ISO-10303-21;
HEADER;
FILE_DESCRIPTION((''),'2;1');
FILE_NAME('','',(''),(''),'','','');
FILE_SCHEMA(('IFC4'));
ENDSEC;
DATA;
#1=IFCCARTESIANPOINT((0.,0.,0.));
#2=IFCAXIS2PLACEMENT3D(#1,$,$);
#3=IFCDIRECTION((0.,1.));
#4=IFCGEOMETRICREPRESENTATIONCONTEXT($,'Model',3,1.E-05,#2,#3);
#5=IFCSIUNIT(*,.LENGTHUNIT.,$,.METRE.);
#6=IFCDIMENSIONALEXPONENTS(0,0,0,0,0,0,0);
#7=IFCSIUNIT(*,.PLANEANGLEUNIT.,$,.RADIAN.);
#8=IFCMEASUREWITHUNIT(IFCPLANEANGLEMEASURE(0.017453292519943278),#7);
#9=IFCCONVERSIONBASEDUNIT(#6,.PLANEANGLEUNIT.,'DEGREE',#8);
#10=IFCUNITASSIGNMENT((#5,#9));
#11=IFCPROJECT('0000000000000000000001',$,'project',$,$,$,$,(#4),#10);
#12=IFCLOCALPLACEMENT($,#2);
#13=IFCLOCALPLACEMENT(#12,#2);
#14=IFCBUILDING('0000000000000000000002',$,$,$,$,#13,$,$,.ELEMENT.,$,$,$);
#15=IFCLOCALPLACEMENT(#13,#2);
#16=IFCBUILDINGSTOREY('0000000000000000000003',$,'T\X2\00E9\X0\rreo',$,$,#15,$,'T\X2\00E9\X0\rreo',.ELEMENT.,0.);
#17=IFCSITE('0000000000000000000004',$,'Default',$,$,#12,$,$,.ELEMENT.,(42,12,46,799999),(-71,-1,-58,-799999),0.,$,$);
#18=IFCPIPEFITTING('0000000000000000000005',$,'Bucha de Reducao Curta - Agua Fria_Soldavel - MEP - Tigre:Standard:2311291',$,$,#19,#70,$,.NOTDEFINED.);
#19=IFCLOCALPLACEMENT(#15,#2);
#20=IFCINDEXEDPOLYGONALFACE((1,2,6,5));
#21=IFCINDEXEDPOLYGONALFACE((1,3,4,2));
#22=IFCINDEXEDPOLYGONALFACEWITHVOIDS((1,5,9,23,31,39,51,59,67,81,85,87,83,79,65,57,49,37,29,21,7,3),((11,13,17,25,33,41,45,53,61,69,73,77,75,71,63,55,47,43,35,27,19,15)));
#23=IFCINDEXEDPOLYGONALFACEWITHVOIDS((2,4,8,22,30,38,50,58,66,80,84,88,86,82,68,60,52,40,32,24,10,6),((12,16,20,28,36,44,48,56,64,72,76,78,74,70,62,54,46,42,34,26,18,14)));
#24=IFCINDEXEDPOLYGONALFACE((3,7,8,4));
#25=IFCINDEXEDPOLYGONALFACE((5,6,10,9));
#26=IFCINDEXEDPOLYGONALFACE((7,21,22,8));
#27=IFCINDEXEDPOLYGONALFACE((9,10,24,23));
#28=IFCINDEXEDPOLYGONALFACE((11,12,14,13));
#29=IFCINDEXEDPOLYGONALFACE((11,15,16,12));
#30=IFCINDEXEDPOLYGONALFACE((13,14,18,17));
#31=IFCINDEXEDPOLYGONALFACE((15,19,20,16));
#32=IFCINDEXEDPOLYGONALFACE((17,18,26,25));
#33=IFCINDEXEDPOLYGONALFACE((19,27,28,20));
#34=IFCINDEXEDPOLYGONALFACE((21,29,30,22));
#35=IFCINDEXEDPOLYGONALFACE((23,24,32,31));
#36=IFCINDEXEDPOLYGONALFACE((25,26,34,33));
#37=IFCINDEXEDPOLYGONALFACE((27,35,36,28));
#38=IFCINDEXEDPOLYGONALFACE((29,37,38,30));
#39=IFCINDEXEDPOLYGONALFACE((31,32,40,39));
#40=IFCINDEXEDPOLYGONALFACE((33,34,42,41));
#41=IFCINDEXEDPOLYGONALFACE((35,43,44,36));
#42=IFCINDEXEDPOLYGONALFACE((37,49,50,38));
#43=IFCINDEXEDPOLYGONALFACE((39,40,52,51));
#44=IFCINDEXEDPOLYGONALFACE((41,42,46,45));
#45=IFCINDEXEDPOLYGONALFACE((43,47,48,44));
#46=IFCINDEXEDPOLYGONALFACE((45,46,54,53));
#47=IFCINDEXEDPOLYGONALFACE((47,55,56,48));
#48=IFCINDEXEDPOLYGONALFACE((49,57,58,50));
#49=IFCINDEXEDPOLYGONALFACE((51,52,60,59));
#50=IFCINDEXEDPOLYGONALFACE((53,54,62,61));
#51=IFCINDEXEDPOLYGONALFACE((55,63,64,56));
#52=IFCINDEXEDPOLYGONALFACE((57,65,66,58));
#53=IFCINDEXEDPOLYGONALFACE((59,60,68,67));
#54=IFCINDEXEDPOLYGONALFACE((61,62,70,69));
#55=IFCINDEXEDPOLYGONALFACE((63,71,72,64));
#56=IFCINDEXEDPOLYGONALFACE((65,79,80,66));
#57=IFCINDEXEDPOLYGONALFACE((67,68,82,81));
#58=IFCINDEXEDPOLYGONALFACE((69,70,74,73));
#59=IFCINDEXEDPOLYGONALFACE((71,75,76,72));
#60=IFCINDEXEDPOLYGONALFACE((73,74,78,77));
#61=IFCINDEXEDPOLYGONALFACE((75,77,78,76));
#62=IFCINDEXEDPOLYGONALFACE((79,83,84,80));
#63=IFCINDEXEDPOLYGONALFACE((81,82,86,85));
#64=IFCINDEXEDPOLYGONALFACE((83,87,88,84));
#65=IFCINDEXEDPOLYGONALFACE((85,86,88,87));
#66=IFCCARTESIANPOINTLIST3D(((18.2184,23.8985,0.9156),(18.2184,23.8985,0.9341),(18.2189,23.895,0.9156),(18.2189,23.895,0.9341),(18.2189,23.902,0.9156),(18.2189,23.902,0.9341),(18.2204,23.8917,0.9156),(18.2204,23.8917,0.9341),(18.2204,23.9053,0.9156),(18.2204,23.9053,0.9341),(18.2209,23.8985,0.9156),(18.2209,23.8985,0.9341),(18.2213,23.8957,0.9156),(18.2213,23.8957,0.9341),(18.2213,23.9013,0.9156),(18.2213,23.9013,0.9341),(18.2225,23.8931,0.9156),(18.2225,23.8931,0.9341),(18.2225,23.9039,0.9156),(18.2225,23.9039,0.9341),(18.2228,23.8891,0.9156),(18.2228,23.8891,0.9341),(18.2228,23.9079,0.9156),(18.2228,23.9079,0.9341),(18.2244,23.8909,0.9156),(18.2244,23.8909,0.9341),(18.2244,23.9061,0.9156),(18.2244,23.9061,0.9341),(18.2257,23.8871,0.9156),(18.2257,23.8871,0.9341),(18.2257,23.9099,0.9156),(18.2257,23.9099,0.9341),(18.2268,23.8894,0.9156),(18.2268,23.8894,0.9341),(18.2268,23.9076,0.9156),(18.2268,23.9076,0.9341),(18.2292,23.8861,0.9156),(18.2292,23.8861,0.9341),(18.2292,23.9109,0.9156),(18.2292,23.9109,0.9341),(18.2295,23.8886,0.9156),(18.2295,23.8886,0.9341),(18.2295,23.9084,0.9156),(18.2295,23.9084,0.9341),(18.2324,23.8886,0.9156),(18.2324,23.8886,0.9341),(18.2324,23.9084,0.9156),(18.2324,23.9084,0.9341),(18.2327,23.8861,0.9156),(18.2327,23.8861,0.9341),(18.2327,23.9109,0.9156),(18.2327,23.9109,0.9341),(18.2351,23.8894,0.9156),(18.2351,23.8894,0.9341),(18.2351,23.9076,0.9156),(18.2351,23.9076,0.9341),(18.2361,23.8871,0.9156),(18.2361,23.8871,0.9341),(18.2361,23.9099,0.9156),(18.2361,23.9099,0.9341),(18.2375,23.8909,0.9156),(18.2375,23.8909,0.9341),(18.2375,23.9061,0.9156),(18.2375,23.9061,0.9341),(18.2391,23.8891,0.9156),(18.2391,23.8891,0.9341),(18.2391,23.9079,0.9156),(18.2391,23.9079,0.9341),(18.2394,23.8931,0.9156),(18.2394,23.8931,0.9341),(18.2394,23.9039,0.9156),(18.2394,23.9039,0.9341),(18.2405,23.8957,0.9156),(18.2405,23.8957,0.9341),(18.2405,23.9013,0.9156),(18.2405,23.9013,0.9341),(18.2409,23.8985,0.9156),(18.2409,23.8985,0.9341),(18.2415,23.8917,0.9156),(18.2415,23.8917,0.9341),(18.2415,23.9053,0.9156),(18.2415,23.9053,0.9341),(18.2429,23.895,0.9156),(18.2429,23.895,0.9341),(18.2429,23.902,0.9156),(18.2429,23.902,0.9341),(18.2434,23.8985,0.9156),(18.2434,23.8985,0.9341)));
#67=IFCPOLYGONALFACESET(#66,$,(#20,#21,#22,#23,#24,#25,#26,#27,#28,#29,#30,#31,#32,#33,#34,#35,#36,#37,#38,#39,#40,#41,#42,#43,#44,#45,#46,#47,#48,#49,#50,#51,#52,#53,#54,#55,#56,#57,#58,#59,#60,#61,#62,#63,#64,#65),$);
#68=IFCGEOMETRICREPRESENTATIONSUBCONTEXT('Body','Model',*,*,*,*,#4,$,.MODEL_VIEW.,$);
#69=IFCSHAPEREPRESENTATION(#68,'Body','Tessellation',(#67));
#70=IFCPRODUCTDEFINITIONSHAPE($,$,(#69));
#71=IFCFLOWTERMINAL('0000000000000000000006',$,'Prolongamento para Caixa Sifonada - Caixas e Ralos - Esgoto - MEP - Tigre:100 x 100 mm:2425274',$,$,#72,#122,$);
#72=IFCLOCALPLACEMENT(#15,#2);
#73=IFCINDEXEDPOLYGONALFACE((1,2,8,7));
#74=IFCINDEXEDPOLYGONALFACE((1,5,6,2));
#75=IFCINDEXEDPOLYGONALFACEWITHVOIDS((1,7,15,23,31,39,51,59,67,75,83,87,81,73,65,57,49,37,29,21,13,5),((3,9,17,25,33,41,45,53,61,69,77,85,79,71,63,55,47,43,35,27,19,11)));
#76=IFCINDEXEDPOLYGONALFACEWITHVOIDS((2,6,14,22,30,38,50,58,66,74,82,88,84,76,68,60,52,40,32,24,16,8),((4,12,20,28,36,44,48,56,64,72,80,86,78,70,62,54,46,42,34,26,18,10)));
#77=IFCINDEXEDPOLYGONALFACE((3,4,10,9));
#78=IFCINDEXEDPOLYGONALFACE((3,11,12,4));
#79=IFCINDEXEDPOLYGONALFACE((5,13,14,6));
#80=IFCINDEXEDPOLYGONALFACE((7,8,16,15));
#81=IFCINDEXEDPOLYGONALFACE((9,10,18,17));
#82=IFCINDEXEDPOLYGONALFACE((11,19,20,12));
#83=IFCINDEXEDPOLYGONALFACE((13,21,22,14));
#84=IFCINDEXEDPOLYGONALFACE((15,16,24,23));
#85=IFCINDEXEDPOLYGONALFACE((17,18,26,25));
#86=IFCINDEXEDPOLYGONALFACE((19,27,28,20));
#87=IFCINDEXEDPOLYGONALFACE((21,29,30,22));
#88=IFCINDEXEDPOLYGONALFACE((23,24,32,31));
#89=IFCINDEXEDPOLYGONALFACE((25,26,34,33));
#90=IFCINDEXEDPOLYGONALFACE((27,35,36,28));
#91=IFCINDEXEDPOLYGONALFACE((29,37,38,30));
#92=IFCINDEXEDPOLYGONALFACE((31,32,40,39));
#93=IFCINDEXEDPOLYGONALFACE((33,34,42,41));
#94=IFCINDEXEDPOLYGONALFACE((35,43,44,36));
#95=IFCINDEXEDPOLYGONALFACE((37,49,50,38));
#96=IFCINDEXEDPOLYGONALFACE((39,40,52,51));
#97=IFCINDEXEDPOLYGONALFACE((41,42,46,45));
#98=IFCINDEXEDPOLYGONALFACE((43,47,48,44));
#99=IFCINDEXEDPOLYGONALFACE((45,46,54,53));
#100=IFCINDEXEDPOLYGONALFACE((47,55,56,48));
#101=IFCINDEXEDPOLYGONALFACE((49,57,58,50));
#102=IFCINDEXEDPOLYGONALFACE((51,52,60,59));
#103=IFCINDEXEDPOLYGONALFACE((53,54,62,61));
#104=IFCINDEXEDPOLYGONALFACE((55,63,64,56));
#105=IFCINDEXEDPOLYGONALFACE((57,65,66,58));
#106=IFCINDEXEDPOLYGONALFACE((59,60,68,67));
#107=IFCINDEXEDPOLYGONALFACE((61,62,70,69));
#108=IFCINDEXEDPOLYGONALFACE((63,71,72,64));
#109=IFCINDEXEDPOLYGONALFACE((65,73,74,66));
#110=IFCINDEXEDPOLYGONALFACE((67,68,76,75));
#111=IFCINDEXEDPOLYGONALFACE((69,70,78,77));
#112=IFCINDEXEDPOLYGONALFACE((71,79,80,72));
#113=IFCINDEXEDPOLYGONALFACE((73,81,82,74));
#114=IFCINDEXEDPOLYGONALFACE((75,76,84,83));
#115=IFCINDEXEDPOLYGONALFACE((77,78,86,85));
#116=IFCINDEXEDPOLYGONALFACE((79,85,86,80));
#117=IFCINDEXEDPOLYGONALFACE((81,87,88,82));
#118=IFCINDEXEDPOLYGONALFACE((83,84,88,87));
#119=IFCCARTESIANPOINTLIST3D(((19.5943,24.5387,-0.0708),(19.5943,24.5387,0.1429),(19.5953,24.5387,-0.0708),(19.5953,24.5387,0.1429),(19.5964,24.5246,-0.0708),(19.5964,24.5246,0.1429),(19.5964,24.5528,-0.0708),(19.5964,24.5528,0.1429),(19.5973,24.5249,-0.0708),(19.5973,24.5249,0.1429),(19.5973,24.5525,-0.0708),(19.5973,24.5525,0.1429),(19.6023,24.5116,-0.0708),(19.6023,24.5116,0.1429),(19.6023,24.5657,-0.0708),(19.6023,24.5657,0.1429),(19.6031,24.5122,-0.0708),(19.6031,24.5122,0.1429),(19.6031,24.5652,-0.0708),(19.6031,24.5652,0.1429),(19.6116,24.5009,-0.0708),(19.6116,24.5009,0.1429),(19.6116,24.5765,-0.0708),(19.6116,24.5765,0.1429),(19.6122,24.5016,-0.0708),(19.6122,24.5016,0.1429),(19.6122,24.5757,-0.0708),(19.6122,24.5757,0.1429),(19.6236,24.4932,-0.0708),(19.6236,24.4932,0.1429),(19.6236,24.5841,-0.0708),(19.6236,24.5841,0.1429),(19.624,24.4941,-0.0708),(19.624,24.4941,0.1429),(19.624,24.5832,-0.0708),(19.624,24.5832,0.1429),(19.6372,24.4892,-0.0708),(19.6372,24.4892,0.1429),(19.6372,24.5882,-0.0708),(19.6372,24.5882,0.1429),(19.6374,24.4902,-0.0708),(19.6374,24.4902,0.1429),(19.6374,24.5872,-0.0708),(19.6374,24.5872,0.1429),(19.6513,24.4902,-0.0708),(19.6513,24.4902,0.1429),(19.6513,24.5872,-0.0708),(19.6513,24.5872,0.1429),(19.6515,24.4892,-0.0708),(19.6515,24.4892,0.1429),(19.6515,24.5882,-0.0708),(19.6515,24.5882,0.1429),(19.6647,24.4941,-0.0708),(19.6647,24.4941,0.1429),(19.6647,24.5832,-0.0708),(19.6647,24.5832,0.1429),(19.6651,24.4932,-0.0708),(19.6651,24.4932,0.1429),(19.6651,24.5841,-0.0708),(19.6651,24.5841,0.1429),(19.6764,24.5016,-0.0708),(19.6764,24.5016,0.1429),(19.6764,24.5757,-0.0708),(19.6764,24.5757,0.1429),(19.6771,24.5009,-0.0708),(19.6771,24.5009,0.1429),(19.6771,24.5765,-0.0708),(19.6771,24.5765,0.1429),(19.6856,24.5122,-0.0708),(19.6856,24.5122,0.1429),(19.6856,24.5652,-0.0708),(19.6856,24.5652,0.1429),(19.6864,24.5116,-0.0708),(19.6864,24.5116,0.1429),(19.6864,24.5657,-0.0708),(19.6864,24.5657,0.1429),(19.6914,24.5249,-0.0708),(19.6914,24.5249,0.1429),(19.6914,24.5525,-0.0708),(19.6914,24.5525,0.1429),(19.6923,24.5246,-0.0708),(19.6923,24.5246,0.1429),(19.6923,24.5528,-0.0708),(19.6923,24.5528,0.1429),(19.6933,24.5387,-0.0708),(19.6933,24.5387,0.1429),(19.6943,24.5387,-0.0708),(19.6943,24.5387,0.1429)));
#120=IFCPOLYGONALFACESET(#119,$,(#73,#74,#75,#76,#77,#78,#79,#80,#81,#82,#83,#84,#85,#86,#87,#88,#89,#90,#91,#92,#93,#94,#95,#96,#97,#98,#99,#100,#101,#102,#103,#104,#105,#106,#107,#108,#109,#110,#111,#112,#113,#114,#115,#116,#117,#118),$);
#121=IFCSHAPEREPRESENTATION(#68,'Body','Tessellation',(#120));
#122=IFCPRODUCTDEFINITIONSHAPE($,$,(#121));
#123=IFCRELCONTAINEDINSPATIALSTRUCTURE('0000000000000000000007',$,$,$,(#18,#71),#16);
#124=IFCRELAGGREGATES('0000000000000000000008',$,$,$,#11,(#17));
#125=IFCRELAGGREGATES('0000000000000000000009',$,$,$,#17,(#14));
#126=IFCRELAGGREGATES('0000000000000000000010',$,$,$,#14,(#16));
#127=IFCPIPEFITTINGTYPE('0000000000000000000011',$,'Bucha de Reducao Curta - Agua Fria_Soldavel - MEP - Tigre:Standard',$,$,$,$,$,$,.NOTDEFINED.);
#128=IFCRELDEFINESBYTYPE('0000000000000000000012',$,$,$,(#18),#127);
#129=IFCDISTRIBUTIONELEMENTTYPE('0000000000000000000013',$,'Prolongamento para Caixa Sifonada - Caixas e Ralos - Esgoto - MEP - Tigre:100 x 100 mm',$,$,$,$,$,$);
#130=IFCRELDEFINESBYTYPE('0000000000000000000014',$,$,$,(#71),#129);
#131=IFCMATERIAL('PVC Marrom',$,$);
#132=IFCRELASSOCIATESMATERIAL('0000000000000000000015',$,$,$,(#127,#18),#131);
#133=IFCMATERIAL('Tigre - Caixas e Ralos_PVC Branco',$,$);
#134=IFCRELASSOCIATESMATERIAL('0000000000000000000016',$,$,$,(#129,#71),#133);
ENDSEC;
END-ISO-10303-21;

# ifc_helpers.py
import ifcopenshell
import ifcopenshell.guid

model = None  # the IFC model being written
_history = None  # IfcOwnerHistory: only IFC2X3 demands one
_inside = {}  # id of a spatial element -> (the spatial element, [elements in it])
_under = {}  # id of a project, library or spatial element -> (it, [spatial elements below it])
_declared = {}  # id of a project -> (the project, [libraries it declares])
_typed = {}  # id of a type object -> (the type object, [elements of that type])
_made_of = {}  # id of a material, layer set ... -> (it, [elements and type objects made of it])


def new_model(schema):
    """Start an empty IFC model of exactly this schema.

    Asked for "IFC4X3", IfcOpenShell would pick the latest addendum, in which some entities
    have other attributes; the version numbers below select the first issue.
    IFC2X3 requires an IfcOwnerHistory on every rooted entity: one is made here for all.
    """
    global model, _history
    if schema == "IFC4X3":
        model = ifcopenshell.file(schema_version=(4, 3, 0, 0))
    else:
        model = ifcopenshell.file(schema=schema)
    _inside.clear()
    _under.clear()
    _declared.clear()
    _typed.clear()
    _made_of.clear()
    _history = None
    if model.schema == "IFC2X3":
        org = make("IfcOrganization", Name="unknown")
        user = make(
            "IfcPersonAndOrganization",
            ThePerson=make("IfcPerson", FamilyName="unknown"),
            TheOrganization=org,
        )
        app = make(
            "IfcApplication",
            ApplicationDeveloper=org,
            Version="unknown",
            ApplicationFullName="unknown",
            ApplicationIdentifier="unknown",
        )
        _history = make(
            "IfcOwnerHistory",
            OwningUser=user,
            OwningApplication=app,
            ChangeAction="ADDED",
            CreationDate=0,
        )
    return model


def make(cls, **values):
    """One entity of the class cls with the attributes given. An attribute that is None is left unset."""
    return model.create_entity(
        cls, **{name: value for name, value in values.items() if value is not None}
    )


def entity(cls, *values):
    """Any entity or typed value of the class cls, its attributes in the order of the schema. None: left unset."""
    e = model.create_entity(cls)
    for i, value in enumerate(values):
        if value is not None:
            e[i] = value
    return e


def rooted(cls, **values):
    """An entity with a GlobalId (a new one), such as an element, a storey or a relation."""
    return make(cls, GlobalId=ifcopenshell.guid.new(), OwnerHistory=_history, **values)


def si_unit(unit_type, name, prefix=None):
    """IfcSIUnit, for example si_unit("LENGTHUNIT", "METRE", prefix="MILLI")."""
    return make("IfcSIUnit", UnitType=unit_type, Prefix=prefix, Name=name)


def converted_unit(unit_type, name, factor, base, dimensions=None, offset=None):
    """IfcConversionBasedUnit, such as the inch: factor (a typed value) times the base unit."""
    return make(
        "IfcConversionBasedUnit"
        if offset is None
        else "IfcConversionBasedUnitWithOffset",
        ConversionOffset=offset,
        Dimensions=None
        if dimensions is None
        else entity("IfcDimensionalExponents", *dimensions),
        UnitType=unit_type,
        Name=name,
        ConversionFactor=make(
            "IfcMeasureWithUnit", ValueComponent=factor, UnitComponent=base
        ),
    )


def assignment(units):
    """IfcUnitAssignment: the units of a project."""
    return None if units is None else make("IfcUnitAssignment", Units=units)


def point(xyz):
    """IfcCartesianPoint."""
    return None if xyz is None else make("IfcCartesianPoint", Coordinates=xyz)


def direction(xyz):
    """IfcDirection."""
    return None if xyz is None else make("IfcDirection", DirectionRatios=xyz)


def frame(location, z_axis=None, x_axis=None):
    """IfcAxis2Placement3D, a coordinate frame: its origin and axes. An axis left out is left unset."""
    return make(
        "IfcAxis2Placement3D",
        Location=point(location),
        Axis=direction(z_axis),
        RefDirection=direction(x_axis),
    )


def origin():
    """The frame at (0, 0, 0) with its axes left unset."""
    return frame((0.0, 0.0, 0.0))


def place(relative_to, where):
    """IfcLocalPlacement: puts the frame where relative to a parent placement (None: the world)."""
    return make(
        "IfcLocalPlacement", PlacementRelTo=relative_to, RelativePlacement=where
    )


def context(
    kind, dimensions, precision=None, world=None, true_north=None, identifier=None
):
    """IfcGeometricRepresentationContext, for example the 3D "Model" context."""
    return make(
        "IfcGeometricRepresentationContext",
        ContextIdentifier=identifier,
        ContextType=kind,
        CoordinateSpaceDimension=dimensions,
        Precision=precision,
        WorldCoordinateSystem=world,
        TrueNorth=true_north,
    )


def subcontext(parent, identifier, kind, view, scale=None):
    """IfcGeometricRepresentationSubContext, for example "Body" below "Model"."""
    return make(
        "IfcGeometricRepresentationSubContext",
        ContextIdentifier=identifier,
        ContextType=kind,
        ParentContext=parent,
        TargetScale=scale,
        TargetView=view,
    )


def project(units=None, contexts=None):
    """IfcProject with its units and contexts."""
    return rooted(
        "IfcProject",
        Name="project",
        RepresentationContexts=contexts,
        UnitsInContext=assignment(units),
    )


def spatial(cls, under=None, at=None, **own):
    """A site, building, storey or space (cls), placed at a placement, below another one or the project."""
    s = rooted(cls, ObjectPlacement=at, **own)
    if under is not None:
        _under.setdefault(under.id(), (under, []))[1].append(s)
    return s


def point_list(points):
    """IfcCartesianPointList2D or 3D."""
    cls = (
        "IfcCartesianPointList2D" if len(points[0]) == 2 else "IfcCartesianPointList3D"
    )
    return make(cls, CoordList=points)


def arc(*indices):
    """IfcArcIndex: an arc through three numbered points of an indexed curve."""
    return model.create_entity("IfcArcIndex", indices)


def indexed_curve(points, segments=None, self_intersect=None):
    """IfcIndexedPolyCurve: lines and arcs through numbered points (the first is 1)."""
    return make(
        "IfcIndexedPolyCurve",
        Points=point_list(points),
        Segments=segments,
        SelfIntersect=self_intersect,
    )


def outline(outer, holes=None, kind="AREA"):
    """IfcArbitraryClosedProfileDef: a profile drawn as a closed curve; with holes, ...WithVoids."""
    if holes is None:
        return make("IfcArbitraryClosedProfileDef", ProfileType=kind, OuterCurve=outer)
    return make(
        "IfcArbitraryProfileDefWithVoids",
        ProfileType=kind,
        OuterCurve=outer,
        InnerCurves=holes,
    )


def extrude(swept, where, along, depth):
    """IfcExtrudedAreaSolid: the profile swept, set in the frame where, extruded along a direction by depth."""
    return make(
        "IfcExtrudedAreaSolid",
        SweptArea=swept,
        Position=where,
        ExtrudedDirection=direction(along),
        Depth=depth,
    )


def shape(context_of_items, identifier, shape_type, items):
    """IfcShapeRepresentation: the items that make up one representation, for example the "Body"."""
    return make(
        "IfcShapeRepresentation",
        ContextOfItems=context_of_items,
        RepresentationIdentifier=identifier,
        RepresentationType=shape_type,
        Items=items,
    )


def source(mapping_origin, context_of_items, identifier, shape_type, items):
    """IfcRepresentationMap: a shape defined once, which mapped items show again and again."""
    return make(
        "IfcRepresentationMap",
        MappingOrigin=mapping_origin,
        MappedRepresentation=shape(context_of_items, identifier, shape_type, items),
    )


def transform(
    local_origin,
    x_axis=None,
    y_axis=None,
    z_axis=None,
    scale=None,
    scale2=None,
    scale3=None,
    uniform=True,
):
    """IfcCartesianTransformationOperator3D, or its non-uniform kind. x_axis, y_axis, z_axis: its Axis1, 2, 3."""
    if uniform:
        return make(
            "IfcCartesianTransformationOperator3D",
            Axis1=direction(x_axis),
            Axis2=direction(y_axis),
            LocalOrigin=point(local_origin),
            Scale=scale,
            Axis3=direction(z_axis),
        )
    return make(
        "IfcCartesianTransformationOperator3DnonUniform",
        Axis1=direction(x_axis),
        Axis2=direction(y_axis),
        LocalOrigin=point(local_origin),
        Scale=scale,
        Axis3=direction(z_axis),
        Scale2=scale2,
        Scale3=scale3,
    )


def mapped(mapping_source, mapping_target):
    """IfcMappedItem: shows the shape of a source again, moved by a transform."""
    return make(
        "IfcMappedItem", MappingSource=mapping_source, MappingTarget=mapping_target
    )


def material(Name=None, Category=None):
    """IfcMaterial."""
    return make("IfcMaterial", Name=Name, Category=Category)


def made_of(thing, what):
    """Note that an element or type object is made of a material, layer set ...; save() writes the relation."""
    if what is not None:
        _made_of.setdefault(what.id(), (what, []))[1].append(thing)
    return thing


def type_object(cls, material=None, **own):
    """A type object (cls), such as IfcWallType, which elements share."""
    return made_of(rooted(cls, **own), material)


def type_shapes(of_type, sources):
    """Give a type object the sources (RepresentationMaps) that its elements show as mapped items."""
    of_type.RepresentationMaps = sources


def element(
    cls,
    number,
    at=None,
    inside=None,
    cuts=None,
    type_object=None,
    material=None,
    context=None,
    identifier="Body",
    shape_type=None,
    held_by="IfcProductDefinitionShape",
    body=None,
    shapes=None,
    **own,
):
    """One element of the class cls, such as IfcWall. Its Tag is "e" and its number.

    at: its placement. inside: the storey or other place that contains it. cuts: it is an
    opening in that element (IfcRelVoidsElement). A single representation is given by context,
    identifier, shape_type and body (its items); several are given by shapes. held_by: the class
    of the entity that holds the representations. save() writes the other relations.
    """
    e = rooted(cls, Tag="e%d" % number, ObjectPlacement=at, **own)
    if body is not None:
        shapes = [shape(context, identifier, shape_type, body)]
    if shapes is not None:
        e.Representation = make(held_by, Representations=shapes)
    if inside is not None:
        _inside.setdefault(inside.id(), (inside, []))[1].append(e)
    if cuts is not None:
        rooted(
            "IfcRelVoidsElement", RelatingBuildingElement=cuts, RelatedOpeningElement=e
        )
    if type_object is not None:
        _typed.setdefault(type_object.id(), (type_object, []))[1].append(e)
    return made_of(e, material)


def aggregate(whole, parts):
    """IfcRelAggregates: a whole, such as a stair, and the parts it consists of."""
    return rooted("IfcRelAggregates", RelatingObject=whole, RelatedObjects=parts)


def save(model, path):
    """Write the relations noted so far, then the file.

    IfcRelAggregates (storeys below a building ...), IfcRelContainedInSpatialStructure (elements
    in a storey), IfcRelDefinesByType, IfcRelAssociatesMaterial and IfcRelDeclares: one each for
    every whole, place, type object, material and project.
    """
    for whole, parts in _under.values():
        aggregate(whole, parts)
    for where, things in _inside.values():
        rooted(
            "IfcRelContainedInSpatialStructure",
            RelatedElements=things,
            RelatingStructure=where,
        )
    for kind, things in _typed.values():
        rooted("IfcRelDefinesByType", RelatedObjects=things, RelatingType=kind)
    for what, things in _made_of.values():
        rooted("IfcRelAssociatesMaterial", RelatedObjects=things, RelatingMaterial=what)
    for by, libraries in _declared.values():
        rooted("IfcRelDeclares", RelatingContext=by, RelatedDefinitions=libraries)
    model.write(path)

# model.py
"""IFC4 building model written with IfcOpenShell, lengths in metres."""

from ifc_helpers import new_model, entity, si_unit, converted_unit, direction, frame, origin, place, context, subcontext, project, spatial, arc, indexed_curve, outline, extrude, source, transform, mapped, material, type_object, type_shapes, element, save


model = new_model("IFC4")

# Units and contexts
model_context = context("Model", 3, precision=1e-05, world=origin(), true_north=direction((0.0, 1.0)))
body_context = subcontext(model_context, "Body", "Model", "MODEL_VIEW")
ifc_project = project(units=[si_unit("LENGTHUNIT", "METRE"), converted_unit("PLANEANGLEUNIT", "DEGREE", entity("IfcPlaneAngleMeasure", 0.017453292519943278), si_unit("PLANEANGLEUNIT", "RADIAN"), dimensions=[0, 0, 0, 0, 0, 0, 0])], contexts=[model_context])

# Site, building, storey
site_placement = place(None, origin())
site = spatial("IfcSite", under=ifc_project, at=site_placement, Name="Default", CompositionType="ELEMENT", RefLatitude=(42, 12, 46, 799999), RefLongitude=(-71, -1, -58, -799999), RefElevation=0.0)
building_placement = place(site_placement, origin())
building = spatial("IfcBuilding", under=site, at=building_placement, CompositionType="ELEMENT")
storey_placement = place(building_placement, origin())
storey = spatial("IfcBuildingStorey", under=building, at=storey_placement, Name="Térreo", LongName="Térreo", CompositionType="ELEMENT", Elevation=0.0)

# Pipe fitting
ifc_material_1 = material(Name="PVC Marrom")
pipe_fitting_type_1 = type_object("IfcPipeFittingType", Name="Bucha de Reducao Curta - Agua Fria_Soldavel - MEP - Tigre:Standard", PredefinedType="NOTDEFINED", material=ifc_material_1)
shared_shape_1 = source(origin(), body_context, "Body", "SweptSolid", [
    extrude(outline(indexed_curve([(-0.0125, 0.0), (0.0, -0.0125), (0.0125, 0.0), (0.0, 0.0125)], segments=[arc(1, 2, 3), arc(3, 4, 1)], self_intersect=False), holes=[indexed_curve([(-0.01, 0.0), (0.0, 0.01), (0.01, 0.0), (0.0, -0.01)], segments=[arc(1, 2, 3), arc(3, 4, 1)], self_intersect=False)]), frame((0.0, 0.0, 0.0), z_axis=(1.0, 0.0, 0.0), x_axis=(0.0, -1.0, 0.0)), (0.0, 0.0, 1.0), 0.0185),
])
type_shapes(pipe_fitting_type_1, [shared_shape_1])
pipe_fitting_placement = place(storey_placement, frame((18.2309, 23.8985, 0.9341), z_axis=(0.0, -1.0, 0.0), x_axis=(-0.000084, 0.0, -1.0)))
element("IfcPipeFitting", 1, at=pipe_fitting_placement, inside=storey, type_object=pipe_fitting_type_1, material=ifc_material_1, Name="Bucha de Reducao Curta - Agua Fria_Soldavel - MEP - Tigre:Standard:2311291", PredefinedType="NOTDEFINED", context=body_context, shape_type="MappedRepresentation", body=[
    mapped(shared_shape_1, transform((0.0, 0.0, 0.0), scale=1.0)),
])

# Flow terminal
ifc_material_2 = material(Name="Tigre - Caixas e Ralos_PVC Branco")
distribution_element_type = type_object("IfcDistributionElementType", Name="Prolongamento para Caixa Sifonada - Caixas e Ralos - Esgoto - MEP - Tigre:100 x 100 mm", material=ifc_material_2)
shared_shape_2 = source(origin(), body_context, "Body", "SweptSolid", [
    extrude(outline(indexed_curve([(-0.05, 0.0), (0.0, -0.05), (0.05, 0.0), (0.0, 0.05)], segments=[arc(1, 2, 3), arc(3, 4, 1)], self_intersect=False), holes=[indexed_curve([(-0.049, 0.0), (0.0, 0.049), (0.049, 0.0), (0.0, -0.049)], segments=[arc(1, 2, 3), arc(3, 4, 1)], self_intersect=False)]), frame((0.0, 0.0, -0.2137)), (0.0, 0.0, 1.0), 0.2137),
])
type_shapes(distribution_element_type, [shared_shape_2])
flow_terminal_placement = place(storey_placement, frame((19.6443, 24.5387, 0.1429)))
element("IfcFlowTerminal", 2, at=flow_terminal_placement, inside=storey, type_object=distribution_element_type, material=ifc_material_2, Name="Prolongamento para Caixa Sifonada - Caixas e Ralos - Esgoto - MEP - Tigre:100 x 100 mm:2425274", context=body_context, shape_type="MappedRepresentation", body=[
    mapped(shared_shape_2, transform((0.0, 0.0, 0.0), scale=1.0)),
])

save(model, "model.ifc")
